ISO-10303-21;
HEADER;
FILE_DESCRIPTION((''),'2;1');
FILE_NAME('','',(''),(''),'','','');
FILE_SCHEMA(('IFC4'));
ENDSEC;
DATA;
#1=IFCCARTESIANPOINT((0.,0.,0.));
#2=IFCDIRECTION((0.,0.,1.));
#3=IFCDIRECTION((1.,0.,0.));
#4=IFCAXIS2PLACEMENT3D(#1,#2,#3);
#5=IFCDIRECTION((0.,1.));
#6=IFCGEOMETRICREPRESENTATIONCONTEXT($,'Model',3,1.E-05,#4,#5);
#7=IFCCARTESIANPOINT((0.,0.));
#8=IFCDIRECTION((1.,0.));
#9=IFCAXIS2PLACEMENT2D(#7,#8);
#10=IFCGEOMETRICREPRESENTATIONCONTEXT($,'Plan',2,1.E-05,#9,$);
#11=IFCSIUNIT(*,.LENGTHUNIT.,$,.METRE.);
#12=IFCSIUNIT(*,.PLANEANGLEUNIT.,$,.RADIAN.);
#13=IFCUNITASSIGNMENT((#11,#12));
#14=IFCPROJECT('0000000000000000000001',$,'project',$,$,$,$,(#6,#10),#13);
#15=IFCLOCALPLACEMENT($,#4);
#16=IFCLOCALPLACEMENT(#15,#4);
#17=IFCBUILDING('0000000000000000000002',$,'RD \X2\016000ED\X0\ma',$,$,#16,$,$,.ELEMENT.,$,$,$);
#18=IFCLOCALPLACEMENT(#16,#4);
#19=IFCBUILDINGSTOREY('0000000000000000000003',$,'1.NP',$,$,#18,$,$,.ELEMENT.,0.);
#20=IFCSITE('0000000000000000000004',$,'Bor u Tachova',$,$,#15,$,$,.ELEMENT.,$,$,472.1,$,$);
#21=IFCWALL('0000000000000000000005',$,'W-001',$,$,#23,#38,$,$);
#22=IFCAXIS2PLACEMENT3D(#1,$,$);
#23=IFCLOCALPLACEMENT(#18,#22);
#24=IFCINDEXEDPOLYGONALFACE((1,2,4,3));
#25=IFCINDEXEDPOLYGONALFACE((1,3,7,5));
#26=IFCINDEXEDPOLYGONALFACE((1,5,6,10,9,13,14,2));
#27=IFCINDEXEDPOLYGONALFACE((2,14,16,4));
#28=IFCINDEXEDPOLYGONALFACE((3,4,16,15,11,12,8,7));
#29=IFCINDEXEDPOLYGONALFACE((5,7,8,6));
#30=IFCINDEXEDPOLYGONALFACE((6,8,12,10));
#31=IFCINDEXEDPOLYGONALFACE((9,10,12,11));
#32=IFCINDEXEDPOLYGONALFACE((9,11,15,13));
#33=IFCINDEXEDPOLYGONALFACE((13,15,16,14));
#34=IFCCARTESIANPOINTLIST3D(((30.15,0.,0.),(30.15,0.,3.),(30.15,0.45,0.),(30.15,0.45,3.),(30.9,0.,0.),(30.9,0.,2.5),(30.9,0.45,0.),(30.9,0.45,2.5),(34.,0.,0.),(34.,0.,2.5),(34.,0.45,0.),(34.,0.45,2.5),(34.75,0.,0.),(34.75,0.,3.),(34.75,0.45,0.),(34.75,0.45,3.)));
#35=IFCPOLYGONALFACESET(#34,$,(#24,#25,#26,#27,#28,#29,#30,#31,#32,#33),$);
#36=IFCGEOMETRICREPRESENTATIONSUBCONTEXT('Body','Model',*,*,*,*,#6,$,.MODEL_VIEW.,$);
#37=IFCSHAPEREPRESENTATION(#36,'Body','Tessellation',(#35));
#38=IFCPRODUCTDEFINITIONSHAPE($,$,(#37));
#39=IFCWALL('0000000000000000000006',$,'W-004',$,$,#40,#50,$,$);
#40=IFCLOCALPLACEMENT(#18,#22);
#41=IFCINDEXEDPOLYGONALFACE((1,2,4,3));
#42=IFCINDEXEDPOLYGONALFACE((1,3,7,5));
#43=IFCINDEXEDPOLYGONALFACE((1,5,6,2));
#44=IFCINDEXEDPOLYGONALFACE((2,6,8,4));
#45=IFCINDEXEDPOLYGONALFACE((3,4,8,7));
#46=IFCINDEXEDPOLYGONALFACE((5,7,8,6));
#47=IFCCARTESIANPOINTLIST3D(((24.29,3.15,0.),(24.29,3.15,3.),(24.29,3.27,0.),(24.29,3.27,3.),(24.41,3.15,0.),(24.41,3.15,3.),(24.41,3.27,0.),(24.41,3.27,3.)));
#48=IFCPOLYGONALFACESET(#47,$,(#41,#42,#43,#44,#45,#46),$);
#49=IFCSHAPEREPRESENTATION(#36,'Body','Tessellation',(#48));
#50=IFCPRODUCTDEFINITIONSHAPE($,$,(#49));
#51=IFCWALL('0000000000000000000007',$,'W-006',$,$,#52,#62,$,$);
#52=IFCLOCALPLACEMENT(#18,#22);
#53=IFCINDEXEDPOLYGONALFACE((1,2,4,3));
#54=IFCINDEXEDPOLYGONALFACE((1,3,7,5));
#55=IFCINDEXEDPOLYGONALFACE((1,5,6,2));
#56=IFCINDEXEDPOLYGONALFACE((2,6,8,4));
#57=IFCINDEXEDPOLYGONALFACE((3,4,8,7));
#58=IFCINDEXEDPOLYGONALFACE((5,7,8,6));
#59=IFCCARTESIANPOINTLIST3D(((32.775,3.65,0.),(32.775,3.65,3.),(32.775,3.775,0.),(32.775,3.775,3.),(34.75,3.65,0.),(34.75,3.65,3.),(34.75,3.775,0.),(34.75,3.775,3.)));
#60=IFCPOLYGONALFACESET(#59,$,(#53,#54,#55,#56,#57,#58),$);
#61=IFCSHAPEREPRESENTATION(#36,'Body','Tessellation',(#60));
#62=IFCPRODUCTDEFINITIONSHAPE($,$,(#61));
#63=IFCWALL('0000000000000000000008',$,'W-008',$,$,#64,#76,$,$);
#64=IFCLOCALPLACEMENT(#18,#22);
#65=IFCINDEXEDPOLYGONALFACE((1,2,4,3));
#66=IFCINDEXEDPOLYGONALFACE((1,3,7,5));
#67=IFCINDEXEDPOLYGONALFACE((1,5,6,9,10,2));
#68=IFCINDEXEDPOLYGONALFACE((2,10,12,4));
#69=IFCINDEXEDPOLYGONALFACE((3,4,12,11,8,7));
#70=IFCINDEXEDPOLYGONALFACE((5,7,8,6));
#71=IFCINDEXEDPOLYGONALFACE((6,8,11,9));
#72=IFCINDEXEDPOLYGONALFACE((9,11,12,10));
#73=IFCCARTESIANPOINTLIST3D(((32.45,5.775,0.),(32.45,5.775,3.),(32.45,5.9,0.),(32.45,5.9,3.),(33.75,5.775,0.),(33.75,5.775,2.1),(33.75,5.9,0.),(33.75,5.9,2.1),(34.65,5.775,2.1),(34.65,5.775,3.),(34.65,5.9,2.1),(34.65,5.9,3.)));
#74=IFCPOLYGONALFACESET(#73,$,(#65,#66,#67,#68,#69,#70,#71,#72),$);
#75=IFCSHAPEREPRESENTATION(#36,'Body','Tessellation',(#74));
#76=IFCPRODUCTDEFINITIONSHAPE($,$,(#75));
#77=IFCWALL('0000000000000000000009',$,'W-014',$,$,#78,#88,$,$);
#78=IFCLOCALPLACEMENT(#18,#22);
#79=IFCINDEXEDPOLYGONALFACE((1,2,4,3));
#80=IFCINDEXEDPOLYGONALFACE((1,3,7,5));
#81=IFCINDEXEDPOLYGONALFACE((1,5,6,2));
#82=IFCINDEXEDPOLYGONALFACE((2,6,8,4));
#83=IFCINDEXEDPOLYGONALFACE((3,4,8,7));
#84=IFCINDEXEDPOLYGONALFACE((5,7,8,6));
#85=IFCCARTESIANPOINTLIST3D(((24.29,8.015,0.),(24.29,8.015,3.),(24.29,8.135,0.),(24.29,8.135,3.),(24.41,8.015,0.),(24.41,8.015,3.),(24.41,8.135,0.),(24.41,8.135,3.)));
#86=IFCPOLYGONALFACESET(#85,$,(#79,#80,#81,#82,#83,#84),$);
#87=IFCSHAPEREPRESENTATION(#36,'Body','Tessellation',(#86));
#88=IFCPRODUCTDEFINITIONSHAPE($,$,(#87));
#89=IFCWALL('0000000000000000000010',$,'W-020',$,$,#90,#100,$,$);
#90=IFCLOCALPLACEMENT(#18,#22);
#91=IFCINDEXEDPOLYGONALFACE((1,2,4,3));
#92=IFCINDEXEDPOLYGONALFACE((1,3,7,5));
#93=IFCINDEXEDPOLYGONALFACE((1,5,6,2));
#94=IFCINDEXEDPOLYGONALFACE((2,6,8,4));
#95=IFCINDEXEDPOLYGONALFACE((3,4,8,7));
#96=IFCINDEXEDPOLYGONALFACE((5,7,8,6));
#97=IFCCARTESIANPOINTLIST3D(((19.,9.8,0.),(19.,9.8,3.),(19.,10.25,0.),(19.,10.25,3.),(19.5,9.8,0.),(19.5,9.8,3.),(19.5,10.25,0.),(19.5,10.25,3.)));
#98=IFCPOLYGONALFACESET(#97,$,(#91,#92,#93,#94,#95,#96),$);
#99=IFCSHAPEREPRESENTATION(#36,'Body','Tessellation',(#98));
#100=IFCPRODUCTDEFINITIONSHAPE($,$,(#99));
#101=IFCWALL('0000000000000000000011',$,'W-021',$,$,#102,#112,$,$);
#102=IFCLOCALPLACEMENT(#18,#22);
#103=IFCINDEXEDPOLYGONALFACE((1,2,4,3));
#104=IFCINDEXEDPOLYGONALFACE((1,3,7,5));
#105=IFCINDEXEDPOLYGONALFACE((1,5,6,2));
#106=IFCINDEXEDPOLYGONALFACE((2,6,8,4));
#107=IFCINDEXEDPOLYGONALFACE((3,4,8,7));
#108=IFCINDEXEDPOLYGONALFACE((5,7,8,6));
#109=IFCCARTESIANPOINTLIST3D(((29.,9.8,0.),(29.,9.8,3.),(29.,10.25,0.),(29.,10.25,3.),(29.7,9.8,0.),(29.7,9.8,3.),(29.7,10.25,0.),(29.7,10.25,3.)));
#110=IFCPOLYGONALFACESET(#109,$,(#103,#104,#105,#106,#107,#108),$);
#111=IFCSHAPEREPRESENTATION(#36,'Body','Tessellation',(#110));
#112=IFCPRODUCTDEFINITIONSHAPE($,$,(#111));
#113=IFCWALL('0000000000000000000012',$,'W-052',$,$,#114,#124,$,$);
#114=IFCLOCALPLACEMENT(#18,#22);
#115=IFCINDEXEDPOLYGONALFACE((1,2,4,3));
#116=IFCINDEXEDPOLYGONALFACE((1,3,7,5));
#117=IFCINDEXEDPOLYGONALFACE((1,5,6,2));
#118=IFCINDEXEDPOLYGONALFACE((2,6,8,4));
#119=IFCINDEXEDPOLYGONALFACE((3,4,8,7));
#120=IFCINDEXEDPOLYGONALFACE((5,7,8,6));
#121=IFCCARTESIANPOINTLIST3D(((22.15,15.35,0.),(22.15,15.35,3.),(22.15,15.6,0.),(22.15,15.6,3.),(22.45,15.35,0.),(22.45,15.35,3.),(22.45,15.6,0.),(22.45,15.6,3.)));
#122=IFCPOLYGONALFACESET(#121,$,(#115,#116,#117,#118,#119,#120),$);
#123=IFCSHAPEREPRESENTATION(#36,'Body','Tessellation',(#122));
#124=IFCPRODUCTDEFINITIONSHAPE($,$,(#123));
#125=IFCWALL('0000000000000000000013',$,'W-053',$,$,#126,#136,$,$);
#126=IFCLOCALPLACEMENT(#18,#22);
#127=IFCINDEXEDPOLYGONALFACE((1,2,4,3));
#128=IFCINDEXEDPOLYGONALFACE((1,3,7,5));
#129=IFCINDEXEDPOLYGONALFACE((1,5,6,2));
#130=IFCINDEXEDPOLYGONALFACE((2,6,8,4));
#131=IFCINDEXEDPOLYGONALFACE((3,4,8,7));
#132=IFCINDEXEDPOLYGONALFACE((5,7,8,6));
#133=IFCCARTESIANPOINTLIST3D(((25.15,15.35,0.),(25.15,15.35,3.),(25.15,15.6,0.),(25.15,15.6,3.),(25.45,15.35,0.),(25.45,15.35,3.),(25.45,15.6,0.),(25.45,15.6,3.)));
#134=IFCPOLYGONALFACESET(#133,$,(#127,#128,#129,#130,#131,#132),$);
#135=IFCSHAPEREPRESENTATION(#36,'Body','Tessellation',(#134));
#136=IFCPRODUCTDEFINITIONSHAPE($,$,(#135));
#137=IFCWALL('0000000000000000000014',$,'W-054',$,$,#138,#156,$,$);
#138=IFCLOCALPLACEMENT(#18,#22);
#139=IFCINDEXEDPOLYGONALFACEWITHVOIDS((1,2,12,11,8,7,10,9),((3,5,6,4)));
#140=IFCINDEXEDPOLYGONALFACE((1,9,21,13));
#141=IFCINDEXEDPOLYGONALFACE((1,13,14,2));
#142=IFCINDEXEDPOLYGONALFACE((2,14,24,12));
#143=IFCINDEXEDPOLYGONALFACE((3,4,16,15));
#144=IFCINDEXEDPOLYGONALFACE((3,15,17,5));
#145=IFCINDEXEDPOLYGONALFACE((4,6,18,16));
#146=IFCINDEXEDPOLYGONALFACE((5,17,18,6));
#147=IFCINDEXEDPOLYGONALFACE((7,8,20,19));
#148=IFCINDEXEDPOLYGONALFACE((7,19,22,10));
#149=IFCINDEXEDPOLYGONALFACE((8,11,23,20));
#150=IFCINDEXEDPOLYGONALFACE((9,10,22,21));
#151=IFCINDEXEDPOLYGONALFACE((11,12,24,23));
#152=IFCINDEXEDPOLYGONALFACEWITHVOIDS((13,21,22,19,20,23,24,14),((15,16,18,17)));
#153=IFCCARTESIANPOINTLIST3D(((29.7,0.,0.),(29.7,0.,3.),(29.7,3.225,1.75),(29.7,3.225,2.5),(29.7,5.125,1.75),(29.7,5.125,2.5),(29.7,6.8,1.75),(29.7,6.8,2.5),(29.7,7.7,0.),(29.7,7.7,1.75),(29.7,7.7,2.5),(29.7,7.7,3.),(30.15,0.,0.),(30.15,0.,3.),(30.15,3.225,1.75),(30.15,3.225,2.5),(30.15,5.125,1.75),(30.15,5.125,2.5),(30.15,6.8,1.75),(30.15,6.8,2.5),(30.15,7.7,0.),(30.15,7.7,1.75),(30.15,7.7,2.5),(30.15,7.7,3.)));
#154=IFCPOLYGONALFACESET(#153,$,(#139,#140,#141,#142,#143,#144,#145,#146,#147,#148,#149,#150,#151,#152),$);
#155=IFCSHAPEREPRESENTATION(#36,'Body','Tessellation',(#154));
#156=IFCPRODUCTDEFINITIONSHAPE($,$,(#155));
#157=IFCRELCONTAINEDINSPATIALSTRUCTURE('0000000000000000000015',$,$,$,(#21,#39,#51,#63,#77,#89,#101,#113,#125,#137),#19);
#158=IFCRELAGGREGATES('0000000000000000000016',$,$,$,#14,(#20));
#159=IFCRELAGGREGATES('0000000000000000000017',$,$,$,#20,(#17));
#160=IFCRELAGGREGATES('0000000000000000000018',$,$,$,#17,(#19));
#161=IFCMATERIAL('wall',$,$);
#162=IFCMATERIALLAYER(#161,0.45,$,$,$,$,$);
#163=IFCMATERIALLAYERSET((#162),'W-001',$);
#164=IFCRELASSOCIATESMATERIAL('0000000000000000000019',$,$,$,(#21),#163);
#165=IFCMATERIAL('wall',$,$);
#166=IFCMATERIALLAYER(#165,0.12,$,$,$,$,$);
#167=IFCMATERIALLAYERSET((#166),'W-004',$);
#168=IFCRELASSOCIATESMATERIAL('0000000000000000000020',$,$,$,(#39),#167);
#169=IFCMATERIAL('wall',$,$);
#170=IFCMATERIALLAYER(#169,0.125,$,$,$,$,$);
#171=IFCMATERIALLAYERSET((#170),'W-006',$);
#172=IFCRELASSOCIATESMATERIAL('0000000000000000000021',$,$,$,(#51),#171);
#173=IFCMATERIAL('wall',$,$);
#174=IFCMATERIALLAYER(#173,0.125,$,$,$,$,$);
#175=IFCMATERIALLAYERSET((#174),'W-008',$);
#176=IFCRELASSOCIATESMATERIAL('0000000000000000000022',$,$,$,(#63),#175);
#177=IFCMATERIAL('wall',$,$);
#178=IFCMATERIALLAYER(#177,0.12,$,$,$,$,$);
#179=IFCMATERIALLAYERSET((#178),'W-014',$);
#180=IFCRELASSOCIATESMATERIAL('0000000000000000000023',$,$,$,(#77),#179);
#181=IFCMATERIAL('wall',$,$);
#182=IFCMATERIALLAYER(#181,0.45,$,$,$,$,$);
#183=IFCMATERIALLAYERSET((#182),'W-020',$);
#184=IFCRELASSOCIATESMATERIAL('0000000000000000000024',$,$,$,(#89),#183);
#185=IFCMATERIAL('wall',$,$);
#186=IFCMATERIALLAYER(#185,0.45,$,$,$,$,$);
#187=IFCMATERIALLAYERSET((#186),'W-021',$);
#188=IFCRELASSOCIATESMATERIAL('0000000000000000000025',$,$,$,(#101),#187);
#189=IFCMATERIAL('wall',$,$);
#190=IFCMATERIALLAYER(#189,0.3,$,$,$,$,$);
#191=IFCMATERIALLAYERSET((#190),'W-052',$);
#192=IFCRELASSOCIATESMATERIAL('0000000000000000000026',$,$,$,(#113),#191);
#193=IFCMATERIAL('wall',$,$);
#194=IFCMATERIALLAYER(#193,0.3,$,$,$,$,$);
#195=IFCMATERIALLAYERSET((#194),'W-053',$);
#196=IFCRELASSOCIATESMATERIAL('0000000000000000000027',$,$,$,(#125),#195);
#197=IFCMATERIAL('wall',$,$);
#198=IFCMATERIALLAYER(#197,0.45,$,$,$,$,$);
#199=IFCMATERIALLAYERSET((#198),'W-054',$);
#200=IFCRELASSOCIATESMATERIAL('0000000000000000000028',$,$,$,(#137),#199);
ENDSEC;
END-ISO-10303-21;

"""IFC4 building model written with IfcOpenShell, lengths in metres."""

from ifc_helpers import new_model, si_unit, direction, frame, frame_2d, origin_with_axes, origin_2d_with_axis, place, context, subcontext, project, spatial, line, indexed_curve, rectangle, outline, extrude, material, layer, layer_set, layer_usage, element, save


model = new_model("IFC4")

# Units and contexts
model_context = context("Model", 3, precision=1e-05, world=origin_with_axes(), true_north=direction((0.0, 1.0)))
plan_context = context("Plan", 2, precision=1e-05, world=origin_2d_with_axis())
body_context = subcontext(model_context, "Body", "Model", "MODEL_VIEW")
ifc_project = project(units=[si_unit("LENGTHUNIT", "METRE"), si_unit("PLANEANGLEUNIT", "RADIAN")], contexts=[model_context, plan_context])

# Site, building, storey
site_placement = place(None, origin_with_axes())
site = spatial("IfcSite", under=ifc_project, at=site_placement, Name="Bor u Tachova", CompositionType="ELEMENT", RefElevation=472.1)
building_placement = place(site_placement, origin_with_axes())
building = spatial("IfcBuilding", under=site, at=building_placement, Name="RD Šíma", CompositionType="ELEMENT")
storey_placement = place(building_placement, origin_with_axes())
storey = spatial("IfcBuildingStorey", under=building, at=storey_placement, Name="1.NP", CompositionType="ELEMENT", Elevation=0.0)

# Wall, opening
ifc_material_1 = material(Name="wall")
ifc_layer_1 = layer(ifc_material_1, 0.45)
ifc_layer_set_1 = layer_set([ifc_layer_1], Name="W-001")
ifc_layer_usage_1 = layer_usage(ifc_layer_set_1, "AXIS2", "POSITIVE", -0.225)
wall_1_placement = place(storey_placement, frame((29.925, 0.225, 0.0), z_axis=(0.0, 0.0, 1.0), x_axis=(1.0, 0.0, 0.0)))
wall_1 = element("IfcWall", 1, at=wall_1_placement, inside=storey, material=ifc_layer_usage_1, Name="W-001", context=body_context, shape_type="SweptSolid", body=[
    extrude(outline(indexed_curve([(0.225, -0.225), (0.225, 0.225), (4.825, 0.225), (4.825, -0.225)], segments=[line(1, 2, 3, 4, 1)])), origin_with_axes(), (0.0, 0.0, 1.0), 3.0),
])
opening_1_placement = place(wall_1_placement, frame((0.975, 0.0, 0.0), z_axis=(0.0, 0.0, 1.0), x_axis=(1.0, 0.0, 0.0)))
element("IfcOpeningElement", 2, at=opening_1_placement, cuts=wall_1, PredefinedType="OPENING", context=body_context, shape_type="SweptSolid", body=[
    extrude(rectangle(XDim=3.1, YDim=0.45, at=frame_2d((1.55, 0.0))), origin_with_axes(), (0.0, 0.0, 1.0), 2.5),
])

# Walls
ifc_material_2 = material(Name="wall")
ifc_layer_2 = layer(ifc_material_2, 0.12)
ifc_layer_set_2 = layer_set([ifc_layer_2], Name="W-004")
ifc_layer_usage_2 = layer_usage(ifc_layer_set_2, "AXIS2", "POSITIVE", -0.06)
wall_2_placement = place(storey_placement, frame((24.29, 3.21, 0.0), z_axis=(0.0, 0.0, 1.0), x_axis=(1.0, 0.0, 0.0)))
element("IfcWall", 3, at=wall_2_placement, inside=storey, material=ifc_layer_usage_2, Name="W-004", context=body_context, shape_type="SweptSolid", body=[
    extrude(rectangle(XDim=0.12, YDim=0.12, at=frame_2d((0.06, 0.0))), origin_with_axes(), (0.0, 0.0, 1.0), 3.0),
])
ifc_material_3 = material(Name="wall")
ifc_layer_3 = layer(ifc_material_3, 0.125)
ifc_layer_set_3 = layer_set([ifc_layer_3], Name="W-006")
ifc_layer_usage_3 = layer_usage(ifc_layer_set_3, "AXIS2", "POSITIVE", -0.0625)
wall_3_placement = place(storey_placement, frame((32.775, 3.7125, 0.0), z_axis=(0.0, 0.0, 1.0), x_axis=(1.0, 0.0, 0.0)))
element("IfcWall", 4, at=wall_3_placement, inside=storey, material=ifc_layer_usage_3, Name="W-006", context=body_context, shape_type="SweptSolid", body=[
    extrude(outline(indexed_curve([(0.0, -0.0625), (0.0, 0.0625), (1.975, 0.0625), (1.975, -0.0625)], segments=[line(1, 2, 3, 4, 1)])), origin_with_axes(), (0.0, 0.0, 1.0), 3.0),
])

# Wall, opening
ifc_material_4 = material(Name="wall")
ifc_layer_4 = layer(ifc_material_4, 0.125)
ifc_layer_set_4 = layer_set([ifc_layer_4], Name="W-008")
ifc_layer_usage_4 = layer_usage(ifc_layer_set_4, "AXIS2", "POSITIVE", -0.0625)
wall_4_placement = place(storey_placement, frame((32.45, 5.8375, 0.0), z_axis=(0.0, 0.0, 1.0), x_axis=(1.0, 0.0, 0.0)))
wall_4 = element("IfcWall", 5, at=wall_4_placement, inside=storey, material=ifc_layer_usage_4, Name="W-008", context=body_context, shape_type="SweptSolid", body=[
    extrude(outline(indexed_curve([(0.0, -0.0625), (0.0, 0.0625), (2.2, 0.0625), (2.2, -0.0625)], segments=[line(1, 2, 3, 4, 1)])), origin_with_axes(), (0.0, 0.0, 1.0), 3.0),
])
opening_2_placement = place(wall_4_placement, frame((1.3, 0.0, 0.0), z_axis=(0.0, 0.0, 1.0), x_axis=(1.0, 0.0, 0.0)))
element("IfcOpeningElement", 6, at=opening_2_placement, cuts=wall_4, PredefinedType="OPENING", context=body_context, shape_type="SweptSolid", body=[
    extrude(rectangle(XDim=0.9, YDim=0.125, at=frame_2d((0.45, 0.0))), origin_with_axes(), (0.0, 0.0, 1.0), 2.1),
])

# Wall
ifc_material_5 = material(Name="wall")
ifc_layer_5 = layer(ifc_material_5, 0.12)
ifc_layer_set_5 = layer_set([ifc_layer_5], Name="W-014")
ifc_layer_usage_5 = layer_usage(ifc_layer_set_5, "AXIS2", "POSITIVE", -0.06)
wall_5_placement = place(storey_placement, frame((24.29, 8.075, 0.0), z_axis=(0.0, 0.0, 1.0), x_axis=(1.0, 0.0, 0.0)))
element("IfcWall", 7, at=wall_5_placement, inside=storey, material=ifc_layer_usage_5, Name="W-014", context=body_context, shape_type="SweptSolid", body=[
    extrude(rectangle(XDim=0.12, YDim=0.12, at=frame_2d((0.06, 0.0))), origin_with_axes(), (0.0, 0.0, 1.0), 3.0),
])

# Walls
ifc_material_6 = material(Name="wall")
ifc_layer_6 = layer(ifc_material_6, 0.45)
ifc_layer_set_6 = layer_set([ifc_layer_6], Name="W-020")
ifc_layer_usage_6 = layer_usage(ifc_layer_set_6, "AXIS2", "POSITIVE", -0.225)
wall_6_placement = place(storey_placement, frame((19.0, 10.025, 0.0), z_axis=(0.0, 0.0, 1.0), x_axis=(1.0, 0.0, 0.0)))
element("IfcWall", 8, at=wall_6_placement, inside=storey, material=ifc_layer_usage_6, Name="W-020", context=body_context, shape_type="SweptSolid", body=[
    extrude(rectangle(XDim=0.5, YDim=0.45, at=frame_2d((0.25, 0.0))), origin_with_axes(), (0.0, 0.0, 1.0), 3.0),
])
ifc_material_7 = material(Name="wall")
ifc_layer_7 = layer(ifc_material_7, 0.45)
ifc_layer_set_7 = layer_set([ifc_layer_7], Name="W-021")
ifc_layer_usage_7 = layer_usage(ifc_layer_set_7, "AXIS2", "POSITIVE", -0.225)
wall_7_placement = place(storey_placement, frame((29.0, 10.025, 0.0), z_axis=(0.0, 0.0, 1.0), x_axis=(1.0, 0.0, 0.0)))
element("IfcWall", 9, at=wall_7_placement, inside=storey, material=ifc_layer_usage_7, Name="W-021", context=body_context, shape_type="SweptSolid", body=[
    extrude(rectangle(XDim=0.7, YDim=0.45, at=frame_2d((0.35, 0.0))), origin_with_axes(), (0.0, 0.0, 1.0), 3.0),
])
ifc_material_8 = material(Name="wall")
ifc_layer_8 = layer(ifc_material_8, 0.3)
ifc_layer_set_8 = layer_set([ifc_layer_8], Name="W-052")
ifc_layer_usage_8 = layer_usage(ifc_layer_set_8, "AXIS2", "POSITIVE", -0.15)
wall_8_placement = place(storey_placement, frame((22.3, 15.35, 0.0), z_axis=(0.0, 0.0, 1.0), x_axis=(0.0, 1.0, 0.0)))
element("IfcWall", 10, at=wall_8_placement, inside=storey, material=ifc_layer_usage_8, Name="W-052", context=body_context, shape_type="SweptSolid", body=[
    extrude(outline(indexed_curve([(0.0, -0.15), (0.0, 0.15), (0.25, 0.15), (0.25, -0.15)], segments=[line(1, 2, 3, 4, 1)])), origin_with_axes(), (0.0, 0.0, 1.0), 3.0),
])
ifc_material_9 = material(Name="wall")
ifc_layer_9 = layer(ifc_material_9, 0.3)
ifc_layer_set_9 = layer_set([ifc_layer_9], Name="W-053")
ifc_layer_usage_9 = layer_usage(ifc_layer_set_9, "AXIS2", "POSITIVE", -0.15)
wall_9_placement = place(storey_placement, frame((25.3, 15.35, 0.0), z_axis=(0.0, 0.0, 1.0), x_axis=(0.0, 1.0, 0.0)))
element("IfcWall", 11, at=wall_9_placement, inside=storey, material=ifc_layer_usage_9, Name="W-053", context=body_context, shape_type="SweptSolid", body=[
    extrude(outline(indexed_curve([(0.0, -0.15), (0.0, 0.15), (0.25, 0.15), (0.25, -0.15)], segments=[line(1, 2, 3, 4, 1)])), origin_with_axes(), (0.0, 0.0, 1.0), 3.0),
])

# Wall, openings
ifc_material_10 = material(Name="wall")
ifc_layer_10 = layer(ifc_material_10, 0.45)
ifc_layer_set_10 = layer_set([ifc_layer_10], Name="W-054")
ifc_layer_usage_10 = layer_usage(ifc_layer_set_10, "AXIS2", "POSITIVE", -0.225)
wall_10_placement = place(storey_placement, frame((29.925, 0.225, 0.0), z_axis=(0.0, 0.0, 1.0), x_axis=(0.0, 1.0, 0.0)))
wall_10 = element("IfcWall", 12, at=wall_10_placement, inside=storey, material=ifc_layer_usage_10, Name="W-054", context=body_context, shape_type="SweptSolid", body=[
    extrude(outline(indexed_curve([(0.225, -0.225), (-0.225, -0.225), (-0.225, 0.225), (7.475, 0.225), (7.475, -0.225)], segments=[line(1, 2, 3, 4, 5, 1)])), origin_with_axes(), (0.0, 0.0, 1.0), 3.0),
])
opening_3_placement = place(wall_10_placement, frame((3.0, 0.0, 1.75), z_axis=(0.0, 0.0, 1.0), x_axis=(1.0, 0.0, 0.0)))
element("IfcOpeningElement", 13, at=opening_3_placement, cuts=wall_10, PredefinedType="OPENING", context=body_context, shape_type="SweptSolid", body=[
    extrude(rectangle(XDim=1.9, YDim=0.45, at=frame_2d((0.95, 0.0))), origin_with_axes(), (0.0, 0.0, 1.0), 0.75),
])
opening_4_placement = place(wall_10_placement, frame((6.575, 0.0, 1.75), z_axis=(0.0, 0.0, 1.0), x_axis=(1.0, 0.0, 0.0)))
element("IfcOpeningElement", 14, at=opening_4_placement, cuts=wall_10, PredefinedType="OPENING", context=body_context, shape_type="SweptSolid", body=[
    extrude(rectangle(XDim=0.9, YDim=0.45, at=frame_2d((0.45, 0.0))), origin_with_axes(), (0.0, 0.0, 1.0), 0.75),
])

save(model, "model.ifc")
